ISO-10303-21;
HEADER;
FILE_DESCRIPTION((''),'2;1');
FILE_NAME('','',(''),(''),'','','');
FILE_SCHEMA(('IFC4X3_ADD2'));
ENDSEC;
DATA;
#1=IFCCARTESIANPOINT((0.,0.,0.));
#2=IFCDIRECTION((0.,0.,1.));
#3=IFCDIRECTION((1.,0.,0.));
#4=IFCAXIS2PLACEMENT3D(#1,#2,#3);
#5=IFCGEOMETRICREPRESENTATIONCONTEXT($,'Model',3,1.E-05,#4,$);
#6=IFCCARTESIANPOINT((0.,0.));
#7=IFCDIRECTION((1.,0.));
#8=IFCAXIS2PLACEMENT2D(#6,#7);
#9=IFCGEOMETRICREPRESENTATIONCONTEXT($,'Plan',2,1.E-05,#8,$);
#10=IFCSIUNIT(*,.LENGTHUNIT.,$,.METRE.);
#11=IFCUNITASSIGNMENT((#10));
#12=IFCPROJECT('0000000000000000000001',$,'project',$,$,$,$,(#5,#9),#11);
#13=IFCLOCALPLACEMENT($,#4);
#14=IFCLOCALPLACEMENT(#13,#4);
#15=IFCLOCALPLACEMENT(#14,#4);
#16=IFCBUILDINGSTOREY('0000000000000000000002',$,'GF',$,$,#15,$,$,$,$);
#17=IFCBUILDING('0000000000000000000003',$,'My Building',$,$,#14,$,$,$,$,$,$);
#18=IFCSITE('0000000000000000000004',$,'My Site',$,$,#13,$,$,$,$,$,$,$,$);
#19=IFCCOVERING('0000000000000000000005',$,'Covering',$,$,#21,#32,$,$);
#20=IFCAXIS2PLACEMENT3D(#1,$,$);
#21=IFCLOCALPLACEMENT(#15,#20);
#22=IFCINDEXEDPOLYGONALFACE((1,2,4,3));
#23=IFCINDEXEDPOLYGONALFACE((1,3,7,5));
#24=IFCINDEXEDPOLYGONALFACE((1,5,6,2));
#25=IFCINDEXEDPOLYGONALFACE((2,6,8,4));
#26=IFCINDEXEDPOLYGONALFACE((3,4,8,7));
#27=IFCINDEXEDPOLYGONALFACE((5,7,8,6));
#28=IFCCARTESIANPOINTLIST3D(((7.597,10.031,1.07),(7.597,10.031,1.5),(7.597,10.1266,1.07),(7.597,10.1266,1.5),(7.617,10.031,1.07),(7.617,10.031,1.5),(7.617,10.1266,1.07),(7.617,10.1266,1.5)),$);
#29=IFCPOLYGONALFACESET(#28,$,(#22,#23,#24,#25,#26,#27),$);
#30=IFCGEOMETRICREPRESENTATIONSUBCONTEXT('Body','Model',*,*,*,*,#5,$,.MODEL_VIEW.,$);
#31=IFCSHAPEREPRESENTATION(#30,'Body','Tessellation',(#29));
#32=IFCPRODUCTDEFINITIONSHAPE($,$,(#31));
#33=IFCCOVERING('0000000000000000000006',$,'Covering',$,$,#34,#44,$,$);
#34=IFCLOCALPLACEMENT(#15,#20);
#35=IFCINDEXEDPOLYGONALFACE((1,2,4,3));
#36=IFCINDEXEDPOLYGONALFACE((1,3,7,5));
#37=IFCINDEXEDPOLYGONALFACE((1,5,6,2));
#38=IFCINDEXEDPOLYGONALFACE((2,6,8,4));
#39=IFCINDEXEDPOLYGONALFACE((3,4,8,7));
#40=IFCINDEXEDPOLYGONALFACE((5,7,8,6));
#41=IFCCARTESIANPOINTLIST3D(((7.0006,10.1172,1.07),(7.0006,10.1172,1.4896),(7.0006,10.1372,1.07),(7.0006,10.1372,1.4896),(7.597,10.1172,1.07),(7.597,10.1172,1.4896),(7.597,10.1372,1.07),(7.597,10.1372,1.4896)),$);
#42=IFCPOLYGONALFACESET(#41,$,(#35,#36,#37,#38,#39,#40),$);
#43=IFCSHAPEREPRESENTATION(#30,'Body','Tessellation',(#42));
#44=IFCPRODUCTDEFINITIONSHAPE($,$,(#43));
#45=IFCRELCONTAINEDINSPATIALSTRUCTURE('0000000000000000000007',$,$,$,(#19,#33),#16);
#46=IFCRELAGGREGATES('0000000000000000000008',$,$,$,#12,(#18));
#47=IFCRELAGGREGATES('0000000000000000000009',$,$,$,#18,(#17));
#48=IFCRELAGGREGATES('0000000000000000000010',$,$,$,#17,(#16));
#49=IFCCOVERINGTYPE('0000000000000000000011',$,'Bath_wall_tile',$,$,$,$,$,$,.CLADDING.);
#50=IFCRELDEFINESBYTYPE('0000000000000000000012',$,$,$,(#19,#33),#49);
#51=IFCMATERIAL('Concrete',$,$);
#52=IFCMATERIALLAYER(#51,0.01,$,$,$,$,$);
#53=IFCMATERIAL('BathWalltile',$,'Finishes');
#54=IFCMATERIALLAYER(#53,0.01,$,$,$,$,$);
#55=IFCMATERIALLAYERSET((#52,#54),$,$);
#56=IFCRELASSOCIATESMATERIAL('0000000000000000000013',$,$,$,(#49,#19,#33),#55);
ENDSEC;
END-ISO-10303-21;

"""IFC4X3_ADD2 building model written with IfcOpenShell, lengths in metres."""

from ifc_helpers import new_model, si_unit, frame, origin_with_axes, origin_2d_with_axis, place, context, subcontext, project, spatial, line, indexed_curve, outline, extrude, material, layer, layer_set, layer_usage, type_object, element, save


model = new_model("IFC4X3_ADD2")

# Units and contexts
model_context = context("Model", 3, precision=1e-05, world=origin_with_axes())
plan_context = context("Plan", 2, precision=1e-05, world=origin_2d_with_axis())
body_context_1 = subcontext(model_context, "Body", "Model", "MODEL_VIEW")
ifc_project = project(units=[si_unit("LENGTHUNIT", "METRE")], contexts=[model_context, plan_context])

# Site, building, storey
site_placement = place(None, origin_with_axes())
site = spatial("IfcSite", under=ifc_project, at=site_placement, Name="My Site")
building_placement = place(site_placement, origin_with_axes())
building = spatial("IfcBuilding", under=site, at=building_placement, Name="My Building")
storey_placement = place(building_placement, origin_with_axes())
storey = spatial("IfcBuildingStorey", under=building, at=storey_placement, Name="GF")

# Coverings
ifc_material_1 = material(Name="Concrete")
ifc_layer_1 = layer(ifc_material_1, 0.01)
ifc_material_2 = material(Name="BathWalltile", Category="Finishes")
ifc_layer_2 = layer(ifc_material_2, 0.01)
ifc_layer_set_1 = layer_set([ifc_layer_1, ifc_layer_2])
covering_type = type_object("IfcCoveringType", Name="Bath_wall_tile", PredefinedType="CLADDING", material=ifc_layer_set_1)
ifc_layer_usage_1 = layer_usage(ifc_layer_set_1, "AXIS2", "POSITIVE", 0.0)
covering_1_placement = place(storey_placement, frame((7.617, 10.031, 1.07), z_axis=(0.0, 0.0, 1.0), x_axis=(0.0, 1.0, 0.0)))
element("IfcCovering", 1, at=covering_1_placement, inside=storey, type_object=covering_type, material=ifc_layer_usage_1, Name="Covering", context=body_context_1, shape_type="SweptSolid", body=[
    extrude(outline(indexed_curve([(0.0, 0.0), (0.0, 0.02), (0.0956, 0.02), (0.0956, 0.0)], segments=[line(1, 2, 3, 4, 1)])), origin_with_axes(), (0.0, 0.0, 1.0), 0.43),
])
ifc_layer_usage_2 = layer_usage(ifc_layer_set_1, "AXIS2", "POSITIVE", 0.0)
covering_2_placement = place(storey_placement, frame((7.597, 10.1372, 1.07), z_axis=(0.0, 0.0, 1.0), x_axis=(-1.0, 0.0, 0.0)))
element("IfcCovering", 2, at=covering_2_placement, inside=storey, type_object=covering_type, material=ifc_layer_usage_2, Name="Covering", context=body_context_1, shape_type="SweptSolid", body=[
    extrude(outline(indexed_curve([(0.0, 0.0), (0.0, 0.02), (0.5963, 0.02), (0.5963, 0.0)], segments=[line(1, 2, 3, 4, 1)])), origin_with_axes(), (0.0, 0.0, 1.0), 0.4196),
])

save(model, "model.ifc")
